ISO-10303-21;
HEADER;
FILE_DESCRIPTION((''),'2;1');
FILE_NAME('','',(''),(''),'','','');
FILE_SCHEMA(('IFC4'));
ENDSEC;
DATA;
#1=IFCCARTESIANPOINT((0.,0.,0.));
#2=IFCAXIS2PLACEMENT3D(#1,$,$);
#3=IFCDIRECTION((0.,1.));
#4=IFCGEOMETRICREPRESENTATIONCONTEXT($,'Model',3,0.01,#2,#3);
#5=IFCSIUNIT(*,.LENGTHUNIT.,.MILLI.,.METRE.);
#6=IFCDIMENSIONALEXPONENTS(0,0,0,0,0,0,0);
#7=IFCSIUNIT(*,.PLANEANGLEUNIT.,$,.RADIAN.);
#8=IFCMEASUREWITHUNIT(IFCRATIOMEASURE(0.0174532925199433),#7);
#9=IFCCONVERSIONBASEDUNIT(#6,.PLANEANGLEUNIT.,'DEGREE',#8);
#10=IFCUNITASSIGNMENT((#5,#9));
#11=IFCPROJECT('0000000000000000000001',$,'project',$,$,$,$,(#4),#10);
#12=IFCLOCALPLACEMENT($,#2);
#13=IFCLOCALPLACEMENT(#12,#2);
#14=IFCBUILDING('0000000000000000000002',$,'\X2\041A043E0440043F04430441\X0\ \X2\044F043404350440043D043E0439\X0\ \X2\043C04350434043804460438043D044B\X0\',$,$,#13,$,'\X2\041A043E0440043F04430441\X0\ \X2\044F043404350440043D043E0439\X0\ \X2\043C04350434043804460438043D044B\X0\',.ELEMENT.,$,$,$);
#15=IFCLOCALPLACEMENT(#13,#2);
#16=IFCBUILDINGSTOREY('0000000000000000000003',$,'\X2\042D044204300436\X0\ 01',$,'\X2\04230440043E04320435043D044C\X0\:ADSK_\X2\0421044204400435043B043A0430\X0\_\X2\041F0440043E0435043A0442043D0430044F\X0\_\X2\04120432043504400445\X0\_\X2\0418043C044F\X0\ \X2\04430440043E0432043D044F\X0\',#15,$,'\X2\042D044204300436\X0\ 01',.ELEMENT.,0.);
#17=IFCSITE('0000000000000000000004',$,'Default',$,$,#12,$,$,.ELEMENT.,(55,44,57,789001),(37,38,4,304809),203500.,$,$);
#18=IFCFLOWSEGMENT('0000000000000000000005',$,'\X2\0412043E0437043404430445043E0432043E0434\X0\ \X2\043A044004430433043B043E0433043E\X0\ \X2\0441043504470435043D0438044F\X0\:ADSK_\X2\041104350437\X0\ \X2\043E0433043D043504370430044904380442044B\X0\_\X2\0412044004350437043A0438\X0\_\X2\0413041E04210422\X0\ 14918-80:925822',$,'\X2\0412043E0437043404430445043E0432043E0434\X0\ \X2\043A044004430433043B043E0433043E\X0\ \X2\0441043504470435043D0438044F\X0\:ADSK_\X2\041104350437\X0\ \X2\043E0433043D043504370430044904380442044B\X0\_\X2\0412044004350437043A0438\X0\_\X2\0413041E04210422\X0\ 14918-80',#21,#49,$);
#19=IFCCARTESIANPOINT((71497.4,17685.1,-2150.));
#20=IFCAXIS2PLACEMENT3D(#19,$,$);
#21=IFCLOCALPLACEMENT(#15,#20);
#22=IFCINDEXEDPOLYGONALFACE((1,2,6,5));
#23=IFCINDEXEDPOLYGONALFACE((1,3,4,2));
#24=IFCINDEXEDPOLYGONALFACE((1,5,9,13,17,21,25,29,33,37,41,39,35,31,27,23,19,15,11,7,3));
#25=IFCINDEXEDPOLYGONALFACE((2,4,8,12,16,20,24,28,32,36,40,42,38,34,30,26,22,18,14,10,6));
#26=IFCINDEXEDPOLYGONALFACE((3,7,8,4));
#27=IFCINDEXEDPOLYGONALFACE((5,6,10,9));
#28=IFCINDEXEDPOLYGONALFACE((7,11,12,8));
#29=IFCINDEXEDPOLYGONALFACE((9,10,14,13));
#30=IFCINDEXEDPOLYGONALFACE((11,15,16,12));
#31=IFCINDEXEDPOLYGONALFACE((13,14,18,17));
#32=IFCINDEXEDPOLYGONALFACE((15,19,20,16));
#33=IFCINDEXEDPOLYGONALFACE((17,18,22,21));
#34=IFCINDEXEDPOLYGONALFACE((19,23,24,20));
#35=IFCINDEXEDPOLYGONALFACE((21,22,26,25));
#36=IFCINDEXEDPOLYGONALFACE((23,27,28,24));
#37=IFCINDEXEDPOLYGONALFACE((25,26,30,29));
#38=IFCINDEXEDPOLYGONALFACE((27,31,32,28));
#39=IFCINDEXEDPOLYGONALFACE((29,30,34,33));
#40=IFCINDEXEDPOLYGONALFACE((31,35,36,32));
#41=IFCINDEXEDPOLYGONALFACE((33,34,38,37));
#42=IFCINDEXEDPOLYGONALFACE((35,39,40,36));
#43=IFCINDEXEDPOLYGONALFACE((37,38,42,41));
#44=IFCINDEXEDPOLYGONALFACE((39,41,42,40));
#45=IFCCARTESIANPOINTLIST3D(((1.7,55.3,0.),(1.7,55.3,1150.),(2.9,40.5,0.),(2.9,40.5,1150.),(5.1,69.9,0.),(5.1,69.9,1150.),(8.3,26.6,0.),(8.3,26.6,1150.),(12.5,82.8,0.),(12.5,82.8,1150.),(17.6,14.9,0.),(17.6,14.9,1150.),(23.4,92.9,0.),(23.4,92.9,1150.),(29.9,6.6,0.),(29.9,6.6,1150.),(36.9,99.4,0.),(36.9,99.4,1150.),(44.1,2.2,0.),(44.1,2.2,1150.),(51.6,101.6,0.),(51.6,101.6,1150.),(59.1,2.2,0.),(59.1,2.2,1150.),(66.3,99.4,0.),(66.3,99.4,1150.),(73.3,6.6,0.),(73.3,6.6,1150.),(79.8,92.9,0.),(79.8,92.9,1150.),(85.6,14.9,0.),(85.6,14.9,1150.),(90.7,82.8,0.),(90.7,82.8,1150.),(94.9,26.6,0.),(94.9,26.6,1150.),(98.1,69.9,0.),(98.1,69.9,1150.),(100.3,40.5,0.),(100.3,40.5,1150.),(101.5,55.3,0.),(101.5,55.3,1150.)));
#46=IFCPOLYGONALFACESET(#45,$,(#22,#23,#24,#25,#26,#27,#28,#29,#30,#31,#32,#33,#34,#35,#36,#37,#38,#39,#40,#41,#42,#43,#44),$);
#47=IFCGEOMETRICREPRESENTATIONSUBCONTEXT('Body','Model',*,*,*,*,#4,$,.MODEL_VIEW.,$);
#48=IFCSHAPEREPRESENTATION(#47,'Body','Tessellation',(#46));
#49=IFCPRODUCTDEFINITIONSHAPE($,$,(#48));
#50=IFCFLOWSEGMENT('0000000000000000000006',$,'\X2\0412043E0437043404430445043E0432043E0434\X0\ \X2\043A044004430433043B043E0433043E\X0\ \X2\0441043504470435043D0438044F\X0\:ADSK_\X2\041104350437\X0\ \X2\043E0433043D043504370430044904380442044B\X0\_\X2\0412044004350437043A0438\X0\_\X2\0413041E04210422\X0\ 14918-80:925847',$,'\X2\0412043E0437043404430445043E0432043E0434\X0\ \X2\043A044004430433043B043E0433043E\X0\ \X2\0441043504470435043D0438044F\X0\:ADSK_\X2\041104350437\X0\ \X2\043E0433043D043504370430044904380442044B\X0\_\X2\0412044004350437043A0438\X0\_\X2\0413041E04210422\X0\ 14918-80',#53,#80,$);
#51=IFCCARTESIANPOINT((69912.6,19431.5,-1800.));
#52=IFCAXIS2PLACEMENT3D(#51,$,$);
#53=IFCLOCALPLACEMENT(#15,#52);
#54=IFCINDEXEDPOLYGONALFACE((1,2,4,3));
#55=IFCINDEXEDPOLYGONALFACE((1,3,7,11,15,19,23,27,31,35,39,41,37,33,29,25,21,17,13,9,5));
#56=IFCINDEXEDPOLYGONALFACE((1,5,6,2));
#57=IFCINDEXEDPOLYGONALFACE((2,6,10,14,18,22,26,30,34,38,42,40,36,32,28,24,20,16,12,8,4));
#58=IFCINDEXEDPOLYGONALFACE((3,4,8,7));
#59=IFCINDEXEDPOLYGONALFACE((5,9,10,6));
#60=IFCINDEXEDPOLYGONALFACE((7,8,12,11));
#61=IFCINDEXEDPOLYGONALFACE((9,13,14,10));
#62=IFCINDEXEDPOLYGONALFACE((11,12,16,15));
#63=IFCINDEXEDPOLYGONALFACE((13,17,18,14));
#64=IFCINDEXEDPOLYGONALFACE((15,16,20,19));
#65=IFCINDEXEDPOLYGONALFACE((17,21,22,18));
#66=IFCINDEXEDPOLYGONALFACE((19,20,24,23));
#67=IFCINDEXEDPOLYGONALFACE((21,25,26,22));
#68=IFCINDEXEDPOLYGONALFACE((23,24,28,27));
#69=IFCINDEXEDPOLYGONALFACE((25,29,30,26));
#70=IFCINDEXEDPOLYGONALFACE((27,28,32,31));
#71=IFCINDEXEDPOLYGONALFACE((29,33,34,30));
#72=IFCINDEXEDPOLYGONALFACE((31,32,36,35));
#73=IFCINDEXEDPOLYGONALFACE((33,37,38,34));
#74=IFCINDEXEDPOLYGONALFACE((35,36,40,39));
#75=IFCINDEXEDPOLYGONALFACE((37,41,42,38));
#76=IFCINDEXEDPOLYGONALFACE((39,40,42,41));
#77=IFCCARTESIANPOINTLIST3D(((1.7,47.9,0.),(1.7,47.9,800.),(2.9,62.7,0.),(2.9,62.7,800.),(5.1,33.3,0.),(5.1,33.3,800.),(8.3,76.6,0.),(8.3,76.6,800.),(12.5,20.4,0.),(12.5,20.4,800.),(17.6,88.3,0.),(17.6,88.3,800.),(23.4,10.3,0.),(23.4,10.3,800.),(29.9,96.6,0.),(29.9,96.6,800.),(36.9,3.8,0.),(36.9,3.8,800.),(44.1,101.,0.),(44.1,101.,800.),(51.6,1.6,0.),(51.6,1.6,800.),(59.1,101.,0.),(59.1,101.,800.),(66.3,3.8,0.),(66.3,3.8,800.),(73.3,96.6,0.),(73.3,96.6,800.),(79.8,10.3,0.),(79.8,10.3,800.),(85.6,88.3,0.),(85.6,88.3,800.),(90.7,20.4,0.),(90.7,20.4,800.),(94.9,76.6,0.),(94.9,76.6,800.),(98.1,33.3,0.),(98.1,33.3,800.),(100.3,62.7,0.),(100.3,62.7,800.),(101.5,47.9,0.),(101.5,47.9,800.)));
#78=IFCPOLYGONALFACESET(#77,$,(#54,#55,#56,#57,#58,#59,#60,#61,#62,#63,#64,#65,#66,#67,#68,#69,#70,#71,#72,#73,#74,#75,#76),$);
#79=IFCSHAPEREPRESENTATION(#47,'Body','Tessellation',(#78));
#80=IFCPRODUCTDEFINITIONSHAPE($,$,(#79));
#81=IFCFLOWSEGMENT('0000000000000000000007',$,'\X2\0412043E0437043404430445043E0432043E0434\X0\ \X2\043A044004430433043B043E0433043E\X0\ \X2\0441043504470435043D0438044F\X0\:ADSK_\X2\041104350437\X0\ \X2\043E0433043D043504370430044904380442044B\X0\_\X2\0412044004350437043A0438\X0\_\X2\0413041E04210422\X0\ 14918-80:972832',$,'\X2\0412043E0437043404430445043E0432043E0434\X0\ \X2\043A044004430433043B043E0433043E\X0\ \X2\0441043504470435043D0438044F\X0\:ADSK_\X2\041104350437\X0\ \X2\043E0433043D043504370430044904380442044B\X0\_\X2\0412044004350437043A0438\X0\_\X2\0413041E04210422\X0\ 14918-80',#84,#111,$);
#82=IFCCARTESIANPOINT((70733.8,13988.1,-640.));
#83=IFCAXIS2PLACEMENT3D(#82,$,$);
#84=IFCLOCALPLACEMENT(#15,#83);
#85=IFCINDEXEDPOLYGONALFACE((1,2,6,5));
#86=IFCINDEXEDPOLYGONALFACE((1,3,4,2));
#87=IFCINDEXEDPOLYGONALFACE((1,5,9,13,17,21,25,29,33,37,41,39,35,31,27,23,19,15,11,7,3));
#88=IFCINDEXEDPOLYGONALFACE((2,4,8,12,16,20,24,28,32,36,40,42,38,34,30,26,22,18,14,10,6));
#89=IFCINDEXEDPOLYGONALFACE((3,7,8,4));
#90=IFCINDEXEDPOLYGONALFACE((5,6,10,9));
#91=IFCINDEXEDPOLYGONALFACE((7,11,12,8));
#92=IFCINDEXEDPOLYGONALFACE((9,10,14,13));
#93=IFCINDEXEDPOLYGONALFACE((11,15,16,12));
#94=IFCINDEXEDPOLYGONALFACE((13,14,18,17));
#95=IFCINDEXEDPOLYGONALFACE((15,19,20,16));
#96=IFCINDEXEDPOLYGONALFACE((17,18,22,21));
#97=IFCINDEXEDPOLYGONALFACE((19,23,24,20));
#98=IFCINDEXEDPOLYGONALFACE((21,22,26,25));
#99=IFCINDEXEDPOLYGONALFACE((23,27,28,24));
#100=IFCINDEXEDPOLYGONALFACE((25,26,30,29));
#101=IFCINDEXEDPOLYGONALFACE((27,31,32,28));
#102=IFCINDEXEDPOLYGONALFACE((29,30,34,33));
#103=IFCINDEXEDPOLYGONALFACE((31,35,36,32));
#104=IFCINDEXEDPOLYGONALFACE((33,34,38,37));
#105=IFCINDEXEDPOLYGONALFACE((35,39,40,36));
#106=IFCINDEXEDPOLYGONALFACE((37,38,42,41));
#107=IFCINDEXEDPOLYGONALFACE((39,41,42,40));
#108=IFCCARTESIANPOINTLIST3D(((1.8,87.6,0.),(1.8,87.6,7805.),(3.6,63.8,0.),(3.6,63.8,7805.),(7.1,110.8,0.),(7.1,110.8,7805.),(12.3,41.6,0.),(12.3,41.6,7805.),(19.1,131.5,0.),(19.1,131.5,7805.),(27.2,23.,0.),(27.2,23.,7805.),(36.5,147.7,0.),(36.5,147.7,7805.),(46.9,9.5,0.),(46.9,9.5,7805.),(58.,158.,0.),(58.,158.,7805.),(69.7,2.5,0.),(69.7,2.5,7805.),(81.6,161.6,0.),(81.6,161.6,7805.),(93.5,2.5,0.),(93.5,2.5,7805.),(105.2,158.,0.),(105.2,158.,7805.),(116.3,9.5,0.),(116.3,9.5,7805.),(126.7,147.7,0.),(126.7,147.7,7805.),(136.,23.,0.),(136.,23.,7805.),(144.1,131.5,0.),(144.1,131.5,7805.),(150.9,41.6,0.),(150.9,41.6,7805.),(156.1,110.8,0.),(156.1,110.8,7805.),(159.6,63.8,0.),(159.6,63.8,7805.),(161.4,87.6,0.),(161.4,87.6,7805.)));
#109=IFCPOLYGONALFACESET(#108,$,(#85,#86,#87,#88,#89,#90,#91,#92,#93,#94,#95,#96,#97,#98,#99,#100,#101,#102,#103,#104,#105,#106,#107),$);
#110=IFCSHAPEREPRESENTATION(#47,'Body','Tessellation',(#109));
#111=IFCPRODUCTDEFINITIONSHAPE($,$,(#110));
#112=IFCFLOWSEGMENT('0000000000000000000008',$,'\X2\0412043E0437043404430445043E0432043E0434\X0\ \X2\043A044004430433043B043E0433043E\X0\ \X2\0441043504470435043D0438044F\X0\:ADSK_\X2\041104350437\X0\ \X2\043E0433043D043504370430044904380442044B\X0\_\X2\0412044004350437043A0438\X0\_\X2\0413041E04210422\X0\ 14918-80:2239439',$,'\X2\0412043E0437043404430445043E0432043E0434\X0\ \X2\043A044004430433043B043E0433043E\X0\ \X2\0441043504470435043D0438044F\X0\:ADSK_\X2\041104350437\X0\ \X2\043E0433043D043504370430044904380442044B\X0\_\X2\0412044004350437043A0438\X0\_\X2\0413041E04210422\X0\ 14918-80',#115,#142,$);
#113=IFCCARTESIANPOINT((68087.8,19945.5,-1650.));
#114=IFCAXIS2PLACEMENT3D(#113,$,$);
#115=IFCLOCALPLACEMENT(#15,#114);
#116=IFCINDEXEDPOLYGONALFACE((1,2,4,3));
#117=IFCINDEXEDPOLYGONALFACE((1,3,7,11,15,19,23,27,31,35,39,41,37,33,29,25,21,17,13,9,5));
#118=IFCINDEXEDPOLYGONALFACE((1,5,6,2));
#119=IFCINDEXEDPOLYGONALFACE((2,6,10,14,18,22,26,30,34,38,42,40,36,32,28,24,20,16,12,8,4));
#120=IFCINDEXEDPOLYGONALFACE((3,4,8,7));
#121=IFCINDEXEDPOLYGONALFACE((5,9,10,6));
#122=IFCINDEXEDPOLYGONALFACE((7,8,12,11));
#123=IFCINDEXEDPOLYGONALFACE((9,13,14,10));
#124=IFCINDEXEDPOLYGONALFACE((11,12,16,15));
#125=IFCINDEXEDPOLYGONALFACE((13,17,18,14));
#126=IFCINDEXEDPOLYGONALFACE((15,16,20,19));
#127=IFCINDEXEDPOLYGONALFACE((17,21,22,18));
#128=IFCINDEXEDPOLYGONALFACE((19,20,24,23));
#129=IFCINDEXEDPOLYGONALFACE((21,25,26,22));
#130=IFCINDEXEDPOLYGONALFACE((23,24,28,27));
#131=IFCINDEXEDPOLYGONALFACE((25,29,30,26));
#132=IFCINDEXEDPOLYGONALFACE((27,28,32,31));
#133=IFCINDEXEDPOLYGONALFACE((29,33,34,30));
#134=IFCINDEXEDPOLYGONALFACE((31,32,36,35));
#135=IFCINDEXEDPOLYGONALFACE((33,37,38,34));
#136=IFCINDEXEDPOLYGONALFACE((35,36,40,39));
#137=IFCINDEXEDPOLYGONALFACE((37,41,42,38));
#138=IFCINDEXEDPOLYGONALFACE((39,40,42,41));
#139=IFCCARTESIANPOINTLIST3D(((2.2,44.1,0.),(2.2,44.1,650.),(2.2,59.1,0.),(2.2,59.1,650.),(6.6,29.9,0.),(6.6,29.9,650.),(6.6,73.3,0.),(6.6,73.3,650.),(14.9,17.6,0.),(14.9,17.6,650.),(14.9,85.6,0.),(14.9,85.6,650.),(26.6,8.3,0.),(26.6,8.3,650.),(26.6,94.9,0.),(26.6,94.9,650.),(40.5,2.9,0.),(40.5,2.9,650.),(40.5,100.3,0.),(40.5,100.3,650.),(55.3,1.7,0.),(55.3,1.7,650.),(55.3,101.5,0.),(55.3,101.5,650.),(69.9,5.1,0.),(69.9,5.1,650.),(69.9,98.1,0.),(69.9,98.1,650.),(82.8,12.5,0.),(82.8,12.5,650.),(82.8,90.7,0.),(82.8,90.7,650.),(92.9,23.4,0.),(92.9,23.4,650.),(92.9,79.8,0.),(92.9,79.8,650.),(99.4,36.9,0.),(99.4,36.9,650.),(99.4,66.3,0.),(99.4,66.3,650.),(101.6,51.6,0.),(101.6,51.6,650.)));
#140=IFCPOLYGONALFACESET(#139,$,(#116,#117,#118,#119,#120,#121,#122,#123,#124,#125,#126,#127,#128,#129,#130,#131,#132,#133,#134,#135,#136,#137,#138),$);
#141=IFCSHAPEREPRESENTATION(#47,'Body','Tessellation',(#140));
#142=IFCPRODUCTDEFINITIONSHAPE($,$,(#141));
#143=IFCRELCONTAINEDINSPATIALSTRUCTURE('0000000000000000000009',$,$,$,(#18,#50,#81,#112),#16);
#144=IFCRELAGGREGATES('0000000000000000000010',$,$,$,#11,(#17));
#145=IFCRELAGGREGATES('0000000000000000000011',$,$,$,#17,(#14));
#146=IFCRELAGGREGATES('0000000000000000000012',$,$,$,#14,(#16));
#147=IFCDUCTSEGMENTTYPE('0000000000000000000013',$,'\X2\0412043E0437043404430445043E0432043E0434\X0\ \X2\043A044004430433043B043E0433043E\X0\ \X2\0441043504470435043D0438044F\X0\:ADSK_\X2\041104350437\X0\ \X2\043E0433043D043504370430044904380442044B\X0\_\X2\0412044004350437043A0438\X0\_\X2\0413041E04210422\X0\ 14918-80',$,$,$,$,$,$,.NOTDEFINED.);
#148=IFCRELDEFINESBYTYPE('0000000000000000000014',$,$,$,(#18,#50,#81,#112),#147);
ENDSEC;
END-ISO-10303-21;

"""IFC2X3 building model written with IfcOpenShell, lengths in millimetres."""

from ifc_helpers import new_model, entity, si_unit, converted_unit, direction, frame, origin, origin_2d_with_axis, place, context, subcontext, project, spatial, circle, extrude, type_object, element, save


model = new_model("IFC2X3")

# Units and contexts
model_context = context("Model", 3, precision=0.01, world=origin(), true_north=direction((0.0, 1.0)))
body_context = subcontext(model_context, "Body", "Model", "MODEL_VIEW")
ifc_project = project(units=[si_unit("LENGTHUNIT", "METRE", prefix="MILLI"), converted_unit("PLANEANGLEUNIT", "DEGREE", entity("IfcRatioMeasure", 0.0174532925199433), si_unit("PLANEANGLEUNIT", "RADIAN"), dimensions=[0, 0, 0, 0, 0, 0, 0])], contexts=[model_context])

# Site, building, storey
site_placement = place(None, origin())
site = spatial("IfcSite", under=ifc_project, at=site_placement, Name="Default", CompositionType="ELEMENT", RefLatitude=(55, 44, 57, 789001), RefLongitude=(37, 38, 4, 304809), RefElevation=203500.0)
building_placement = place(site_placement, origin())
building = spatial("IfcBuilding", under=site, at=building_placement, Name="Корпус ядерной медицины", LongName="Корпус ядерной медицины", CompositionType="ELEMENT")
storey_placement = place(building_placement, origin())
storey = spatial("IfcBuildingStorey", under=building, at=storey_placement, Name="Этаж 01", ObjectType="Уровень:ADSK_Стрелка_Проектная_Вверх_Имя уровня", LongName="Этаж 01", CompositionType="ELEMENT", Elevation=0.0)

# Flow segments
duct_segment_type = type_object("IfcDuctSegmentType", Name="Воздуховод круглого сечения:ADSK_Без огнезащиты_Врезки_ГОСТ 14918-80", PredefinedType="NOTDEFINED")
flow_segment_1_placement = place(storey_placement, frame((71497.4, 17685.1, -2150.0)))
element("IfcFlowSegment", 1, at=flow_segment_1_placement, inside=storey, type_object=duct_segment_type, Name="Воздуховод круглого сечения:ADSK_Без огнезащиты_Врезки_ГОСТ 14918-80:925822", ObjectType="Воздуховод круглого сечения:ADSK_Без огнезащиты_Врезки_ГОСТ 14918-80", context=body_context, shape_type="SweptSolid", body=[
    extrude(circle(Radius=50.0, at=origin_2d_with_axis()), frame((51.6, 51.6, 0.0), z_axis=(0.0, 0.0, 1.0), x_axis=(0.0, 1.0, 0.0)), (0.0, 0.0, 1.0), 1150.0),
])
flow_segment_2_placement = place(storey_placement, frame((69912.6, 19431.5, -1800.0)))
element("IfcFlowSegment", 2, at=flow_segment_2_placement, inside=storey, type_object=duct_segment_type, Name="Воздуховод круглого сечения:ADSK_Без огнезащиты_Врезки_ГОСТ 14918-80:925847", ObjectType="Воздуховод круглого сечения:ADSK_Без огнезащиты_Врезки_ГОСТ 14918-80", context=body_context, shape_type="SweptSolid", body=[
    extrude(circle(Radius=50.0, at=origin_2d_with_axis()), frame((51.6, 51.6, 0.0), z_axis=(0.0, 0.0, 1.0), x_axis=(0.0, -1.0, 0.0)), (0.0, 0.0, 1.0), 800.0),
])
flow_segment_3_placement = place(storey_placement, frame((70733.8, 13988.1, -640.0)))
element("IfcFlowSegment", 3, at=flow_segment_3_placement, inside=storey, type_object=duct_segment_type, Name="Воздуховод круглого сечения:ADSK_Без огнезащиты_Врезки_ГОСТ 14918-80:972832", ObjectType="Воздуховод круглого сечения:ADSK_Без огнезащиты_Врезки_ГОСТ 14918-80", context=body_context, shape_type="SweptSolid", body=[
    extrude(circle(Radius=80.0, at=origin_2d_with_axis()), frame((81.6, 81.6, 0.0), z_axis=(0.0, 0.0, 1.0), x_axis=(0.0, 1.0, 0.0)), (0.0, 0.0, 1.0), 7805.0),
])
flow_segment_4_placement = place(storey_placement, frame((68087.8, 19945.5, -1650.0)))
element("IfcFlowSegment", 4, at=flow_segment_4_placement, inside=storey, type_object=duct_segment_type, Name="Воздуховод круглого сечения:ADSK_Без огнезащиты_Врезки_ГОСТ 14918-80:2239439", ObjectType="Воздуховод круглого сечения:ADSK_Без огнезащиты_Врезки_ГОСТ 14918-80", context=body_context, shape_type="SweptSolid", body=[
    extrude(circle(Radius=50.0, at=origin_2d_with_axis()), frame((51.6, 51.6, 0.0)), (0.0, 0.0, 1.0), 650.0),
])

save(model, "model.ifc")
